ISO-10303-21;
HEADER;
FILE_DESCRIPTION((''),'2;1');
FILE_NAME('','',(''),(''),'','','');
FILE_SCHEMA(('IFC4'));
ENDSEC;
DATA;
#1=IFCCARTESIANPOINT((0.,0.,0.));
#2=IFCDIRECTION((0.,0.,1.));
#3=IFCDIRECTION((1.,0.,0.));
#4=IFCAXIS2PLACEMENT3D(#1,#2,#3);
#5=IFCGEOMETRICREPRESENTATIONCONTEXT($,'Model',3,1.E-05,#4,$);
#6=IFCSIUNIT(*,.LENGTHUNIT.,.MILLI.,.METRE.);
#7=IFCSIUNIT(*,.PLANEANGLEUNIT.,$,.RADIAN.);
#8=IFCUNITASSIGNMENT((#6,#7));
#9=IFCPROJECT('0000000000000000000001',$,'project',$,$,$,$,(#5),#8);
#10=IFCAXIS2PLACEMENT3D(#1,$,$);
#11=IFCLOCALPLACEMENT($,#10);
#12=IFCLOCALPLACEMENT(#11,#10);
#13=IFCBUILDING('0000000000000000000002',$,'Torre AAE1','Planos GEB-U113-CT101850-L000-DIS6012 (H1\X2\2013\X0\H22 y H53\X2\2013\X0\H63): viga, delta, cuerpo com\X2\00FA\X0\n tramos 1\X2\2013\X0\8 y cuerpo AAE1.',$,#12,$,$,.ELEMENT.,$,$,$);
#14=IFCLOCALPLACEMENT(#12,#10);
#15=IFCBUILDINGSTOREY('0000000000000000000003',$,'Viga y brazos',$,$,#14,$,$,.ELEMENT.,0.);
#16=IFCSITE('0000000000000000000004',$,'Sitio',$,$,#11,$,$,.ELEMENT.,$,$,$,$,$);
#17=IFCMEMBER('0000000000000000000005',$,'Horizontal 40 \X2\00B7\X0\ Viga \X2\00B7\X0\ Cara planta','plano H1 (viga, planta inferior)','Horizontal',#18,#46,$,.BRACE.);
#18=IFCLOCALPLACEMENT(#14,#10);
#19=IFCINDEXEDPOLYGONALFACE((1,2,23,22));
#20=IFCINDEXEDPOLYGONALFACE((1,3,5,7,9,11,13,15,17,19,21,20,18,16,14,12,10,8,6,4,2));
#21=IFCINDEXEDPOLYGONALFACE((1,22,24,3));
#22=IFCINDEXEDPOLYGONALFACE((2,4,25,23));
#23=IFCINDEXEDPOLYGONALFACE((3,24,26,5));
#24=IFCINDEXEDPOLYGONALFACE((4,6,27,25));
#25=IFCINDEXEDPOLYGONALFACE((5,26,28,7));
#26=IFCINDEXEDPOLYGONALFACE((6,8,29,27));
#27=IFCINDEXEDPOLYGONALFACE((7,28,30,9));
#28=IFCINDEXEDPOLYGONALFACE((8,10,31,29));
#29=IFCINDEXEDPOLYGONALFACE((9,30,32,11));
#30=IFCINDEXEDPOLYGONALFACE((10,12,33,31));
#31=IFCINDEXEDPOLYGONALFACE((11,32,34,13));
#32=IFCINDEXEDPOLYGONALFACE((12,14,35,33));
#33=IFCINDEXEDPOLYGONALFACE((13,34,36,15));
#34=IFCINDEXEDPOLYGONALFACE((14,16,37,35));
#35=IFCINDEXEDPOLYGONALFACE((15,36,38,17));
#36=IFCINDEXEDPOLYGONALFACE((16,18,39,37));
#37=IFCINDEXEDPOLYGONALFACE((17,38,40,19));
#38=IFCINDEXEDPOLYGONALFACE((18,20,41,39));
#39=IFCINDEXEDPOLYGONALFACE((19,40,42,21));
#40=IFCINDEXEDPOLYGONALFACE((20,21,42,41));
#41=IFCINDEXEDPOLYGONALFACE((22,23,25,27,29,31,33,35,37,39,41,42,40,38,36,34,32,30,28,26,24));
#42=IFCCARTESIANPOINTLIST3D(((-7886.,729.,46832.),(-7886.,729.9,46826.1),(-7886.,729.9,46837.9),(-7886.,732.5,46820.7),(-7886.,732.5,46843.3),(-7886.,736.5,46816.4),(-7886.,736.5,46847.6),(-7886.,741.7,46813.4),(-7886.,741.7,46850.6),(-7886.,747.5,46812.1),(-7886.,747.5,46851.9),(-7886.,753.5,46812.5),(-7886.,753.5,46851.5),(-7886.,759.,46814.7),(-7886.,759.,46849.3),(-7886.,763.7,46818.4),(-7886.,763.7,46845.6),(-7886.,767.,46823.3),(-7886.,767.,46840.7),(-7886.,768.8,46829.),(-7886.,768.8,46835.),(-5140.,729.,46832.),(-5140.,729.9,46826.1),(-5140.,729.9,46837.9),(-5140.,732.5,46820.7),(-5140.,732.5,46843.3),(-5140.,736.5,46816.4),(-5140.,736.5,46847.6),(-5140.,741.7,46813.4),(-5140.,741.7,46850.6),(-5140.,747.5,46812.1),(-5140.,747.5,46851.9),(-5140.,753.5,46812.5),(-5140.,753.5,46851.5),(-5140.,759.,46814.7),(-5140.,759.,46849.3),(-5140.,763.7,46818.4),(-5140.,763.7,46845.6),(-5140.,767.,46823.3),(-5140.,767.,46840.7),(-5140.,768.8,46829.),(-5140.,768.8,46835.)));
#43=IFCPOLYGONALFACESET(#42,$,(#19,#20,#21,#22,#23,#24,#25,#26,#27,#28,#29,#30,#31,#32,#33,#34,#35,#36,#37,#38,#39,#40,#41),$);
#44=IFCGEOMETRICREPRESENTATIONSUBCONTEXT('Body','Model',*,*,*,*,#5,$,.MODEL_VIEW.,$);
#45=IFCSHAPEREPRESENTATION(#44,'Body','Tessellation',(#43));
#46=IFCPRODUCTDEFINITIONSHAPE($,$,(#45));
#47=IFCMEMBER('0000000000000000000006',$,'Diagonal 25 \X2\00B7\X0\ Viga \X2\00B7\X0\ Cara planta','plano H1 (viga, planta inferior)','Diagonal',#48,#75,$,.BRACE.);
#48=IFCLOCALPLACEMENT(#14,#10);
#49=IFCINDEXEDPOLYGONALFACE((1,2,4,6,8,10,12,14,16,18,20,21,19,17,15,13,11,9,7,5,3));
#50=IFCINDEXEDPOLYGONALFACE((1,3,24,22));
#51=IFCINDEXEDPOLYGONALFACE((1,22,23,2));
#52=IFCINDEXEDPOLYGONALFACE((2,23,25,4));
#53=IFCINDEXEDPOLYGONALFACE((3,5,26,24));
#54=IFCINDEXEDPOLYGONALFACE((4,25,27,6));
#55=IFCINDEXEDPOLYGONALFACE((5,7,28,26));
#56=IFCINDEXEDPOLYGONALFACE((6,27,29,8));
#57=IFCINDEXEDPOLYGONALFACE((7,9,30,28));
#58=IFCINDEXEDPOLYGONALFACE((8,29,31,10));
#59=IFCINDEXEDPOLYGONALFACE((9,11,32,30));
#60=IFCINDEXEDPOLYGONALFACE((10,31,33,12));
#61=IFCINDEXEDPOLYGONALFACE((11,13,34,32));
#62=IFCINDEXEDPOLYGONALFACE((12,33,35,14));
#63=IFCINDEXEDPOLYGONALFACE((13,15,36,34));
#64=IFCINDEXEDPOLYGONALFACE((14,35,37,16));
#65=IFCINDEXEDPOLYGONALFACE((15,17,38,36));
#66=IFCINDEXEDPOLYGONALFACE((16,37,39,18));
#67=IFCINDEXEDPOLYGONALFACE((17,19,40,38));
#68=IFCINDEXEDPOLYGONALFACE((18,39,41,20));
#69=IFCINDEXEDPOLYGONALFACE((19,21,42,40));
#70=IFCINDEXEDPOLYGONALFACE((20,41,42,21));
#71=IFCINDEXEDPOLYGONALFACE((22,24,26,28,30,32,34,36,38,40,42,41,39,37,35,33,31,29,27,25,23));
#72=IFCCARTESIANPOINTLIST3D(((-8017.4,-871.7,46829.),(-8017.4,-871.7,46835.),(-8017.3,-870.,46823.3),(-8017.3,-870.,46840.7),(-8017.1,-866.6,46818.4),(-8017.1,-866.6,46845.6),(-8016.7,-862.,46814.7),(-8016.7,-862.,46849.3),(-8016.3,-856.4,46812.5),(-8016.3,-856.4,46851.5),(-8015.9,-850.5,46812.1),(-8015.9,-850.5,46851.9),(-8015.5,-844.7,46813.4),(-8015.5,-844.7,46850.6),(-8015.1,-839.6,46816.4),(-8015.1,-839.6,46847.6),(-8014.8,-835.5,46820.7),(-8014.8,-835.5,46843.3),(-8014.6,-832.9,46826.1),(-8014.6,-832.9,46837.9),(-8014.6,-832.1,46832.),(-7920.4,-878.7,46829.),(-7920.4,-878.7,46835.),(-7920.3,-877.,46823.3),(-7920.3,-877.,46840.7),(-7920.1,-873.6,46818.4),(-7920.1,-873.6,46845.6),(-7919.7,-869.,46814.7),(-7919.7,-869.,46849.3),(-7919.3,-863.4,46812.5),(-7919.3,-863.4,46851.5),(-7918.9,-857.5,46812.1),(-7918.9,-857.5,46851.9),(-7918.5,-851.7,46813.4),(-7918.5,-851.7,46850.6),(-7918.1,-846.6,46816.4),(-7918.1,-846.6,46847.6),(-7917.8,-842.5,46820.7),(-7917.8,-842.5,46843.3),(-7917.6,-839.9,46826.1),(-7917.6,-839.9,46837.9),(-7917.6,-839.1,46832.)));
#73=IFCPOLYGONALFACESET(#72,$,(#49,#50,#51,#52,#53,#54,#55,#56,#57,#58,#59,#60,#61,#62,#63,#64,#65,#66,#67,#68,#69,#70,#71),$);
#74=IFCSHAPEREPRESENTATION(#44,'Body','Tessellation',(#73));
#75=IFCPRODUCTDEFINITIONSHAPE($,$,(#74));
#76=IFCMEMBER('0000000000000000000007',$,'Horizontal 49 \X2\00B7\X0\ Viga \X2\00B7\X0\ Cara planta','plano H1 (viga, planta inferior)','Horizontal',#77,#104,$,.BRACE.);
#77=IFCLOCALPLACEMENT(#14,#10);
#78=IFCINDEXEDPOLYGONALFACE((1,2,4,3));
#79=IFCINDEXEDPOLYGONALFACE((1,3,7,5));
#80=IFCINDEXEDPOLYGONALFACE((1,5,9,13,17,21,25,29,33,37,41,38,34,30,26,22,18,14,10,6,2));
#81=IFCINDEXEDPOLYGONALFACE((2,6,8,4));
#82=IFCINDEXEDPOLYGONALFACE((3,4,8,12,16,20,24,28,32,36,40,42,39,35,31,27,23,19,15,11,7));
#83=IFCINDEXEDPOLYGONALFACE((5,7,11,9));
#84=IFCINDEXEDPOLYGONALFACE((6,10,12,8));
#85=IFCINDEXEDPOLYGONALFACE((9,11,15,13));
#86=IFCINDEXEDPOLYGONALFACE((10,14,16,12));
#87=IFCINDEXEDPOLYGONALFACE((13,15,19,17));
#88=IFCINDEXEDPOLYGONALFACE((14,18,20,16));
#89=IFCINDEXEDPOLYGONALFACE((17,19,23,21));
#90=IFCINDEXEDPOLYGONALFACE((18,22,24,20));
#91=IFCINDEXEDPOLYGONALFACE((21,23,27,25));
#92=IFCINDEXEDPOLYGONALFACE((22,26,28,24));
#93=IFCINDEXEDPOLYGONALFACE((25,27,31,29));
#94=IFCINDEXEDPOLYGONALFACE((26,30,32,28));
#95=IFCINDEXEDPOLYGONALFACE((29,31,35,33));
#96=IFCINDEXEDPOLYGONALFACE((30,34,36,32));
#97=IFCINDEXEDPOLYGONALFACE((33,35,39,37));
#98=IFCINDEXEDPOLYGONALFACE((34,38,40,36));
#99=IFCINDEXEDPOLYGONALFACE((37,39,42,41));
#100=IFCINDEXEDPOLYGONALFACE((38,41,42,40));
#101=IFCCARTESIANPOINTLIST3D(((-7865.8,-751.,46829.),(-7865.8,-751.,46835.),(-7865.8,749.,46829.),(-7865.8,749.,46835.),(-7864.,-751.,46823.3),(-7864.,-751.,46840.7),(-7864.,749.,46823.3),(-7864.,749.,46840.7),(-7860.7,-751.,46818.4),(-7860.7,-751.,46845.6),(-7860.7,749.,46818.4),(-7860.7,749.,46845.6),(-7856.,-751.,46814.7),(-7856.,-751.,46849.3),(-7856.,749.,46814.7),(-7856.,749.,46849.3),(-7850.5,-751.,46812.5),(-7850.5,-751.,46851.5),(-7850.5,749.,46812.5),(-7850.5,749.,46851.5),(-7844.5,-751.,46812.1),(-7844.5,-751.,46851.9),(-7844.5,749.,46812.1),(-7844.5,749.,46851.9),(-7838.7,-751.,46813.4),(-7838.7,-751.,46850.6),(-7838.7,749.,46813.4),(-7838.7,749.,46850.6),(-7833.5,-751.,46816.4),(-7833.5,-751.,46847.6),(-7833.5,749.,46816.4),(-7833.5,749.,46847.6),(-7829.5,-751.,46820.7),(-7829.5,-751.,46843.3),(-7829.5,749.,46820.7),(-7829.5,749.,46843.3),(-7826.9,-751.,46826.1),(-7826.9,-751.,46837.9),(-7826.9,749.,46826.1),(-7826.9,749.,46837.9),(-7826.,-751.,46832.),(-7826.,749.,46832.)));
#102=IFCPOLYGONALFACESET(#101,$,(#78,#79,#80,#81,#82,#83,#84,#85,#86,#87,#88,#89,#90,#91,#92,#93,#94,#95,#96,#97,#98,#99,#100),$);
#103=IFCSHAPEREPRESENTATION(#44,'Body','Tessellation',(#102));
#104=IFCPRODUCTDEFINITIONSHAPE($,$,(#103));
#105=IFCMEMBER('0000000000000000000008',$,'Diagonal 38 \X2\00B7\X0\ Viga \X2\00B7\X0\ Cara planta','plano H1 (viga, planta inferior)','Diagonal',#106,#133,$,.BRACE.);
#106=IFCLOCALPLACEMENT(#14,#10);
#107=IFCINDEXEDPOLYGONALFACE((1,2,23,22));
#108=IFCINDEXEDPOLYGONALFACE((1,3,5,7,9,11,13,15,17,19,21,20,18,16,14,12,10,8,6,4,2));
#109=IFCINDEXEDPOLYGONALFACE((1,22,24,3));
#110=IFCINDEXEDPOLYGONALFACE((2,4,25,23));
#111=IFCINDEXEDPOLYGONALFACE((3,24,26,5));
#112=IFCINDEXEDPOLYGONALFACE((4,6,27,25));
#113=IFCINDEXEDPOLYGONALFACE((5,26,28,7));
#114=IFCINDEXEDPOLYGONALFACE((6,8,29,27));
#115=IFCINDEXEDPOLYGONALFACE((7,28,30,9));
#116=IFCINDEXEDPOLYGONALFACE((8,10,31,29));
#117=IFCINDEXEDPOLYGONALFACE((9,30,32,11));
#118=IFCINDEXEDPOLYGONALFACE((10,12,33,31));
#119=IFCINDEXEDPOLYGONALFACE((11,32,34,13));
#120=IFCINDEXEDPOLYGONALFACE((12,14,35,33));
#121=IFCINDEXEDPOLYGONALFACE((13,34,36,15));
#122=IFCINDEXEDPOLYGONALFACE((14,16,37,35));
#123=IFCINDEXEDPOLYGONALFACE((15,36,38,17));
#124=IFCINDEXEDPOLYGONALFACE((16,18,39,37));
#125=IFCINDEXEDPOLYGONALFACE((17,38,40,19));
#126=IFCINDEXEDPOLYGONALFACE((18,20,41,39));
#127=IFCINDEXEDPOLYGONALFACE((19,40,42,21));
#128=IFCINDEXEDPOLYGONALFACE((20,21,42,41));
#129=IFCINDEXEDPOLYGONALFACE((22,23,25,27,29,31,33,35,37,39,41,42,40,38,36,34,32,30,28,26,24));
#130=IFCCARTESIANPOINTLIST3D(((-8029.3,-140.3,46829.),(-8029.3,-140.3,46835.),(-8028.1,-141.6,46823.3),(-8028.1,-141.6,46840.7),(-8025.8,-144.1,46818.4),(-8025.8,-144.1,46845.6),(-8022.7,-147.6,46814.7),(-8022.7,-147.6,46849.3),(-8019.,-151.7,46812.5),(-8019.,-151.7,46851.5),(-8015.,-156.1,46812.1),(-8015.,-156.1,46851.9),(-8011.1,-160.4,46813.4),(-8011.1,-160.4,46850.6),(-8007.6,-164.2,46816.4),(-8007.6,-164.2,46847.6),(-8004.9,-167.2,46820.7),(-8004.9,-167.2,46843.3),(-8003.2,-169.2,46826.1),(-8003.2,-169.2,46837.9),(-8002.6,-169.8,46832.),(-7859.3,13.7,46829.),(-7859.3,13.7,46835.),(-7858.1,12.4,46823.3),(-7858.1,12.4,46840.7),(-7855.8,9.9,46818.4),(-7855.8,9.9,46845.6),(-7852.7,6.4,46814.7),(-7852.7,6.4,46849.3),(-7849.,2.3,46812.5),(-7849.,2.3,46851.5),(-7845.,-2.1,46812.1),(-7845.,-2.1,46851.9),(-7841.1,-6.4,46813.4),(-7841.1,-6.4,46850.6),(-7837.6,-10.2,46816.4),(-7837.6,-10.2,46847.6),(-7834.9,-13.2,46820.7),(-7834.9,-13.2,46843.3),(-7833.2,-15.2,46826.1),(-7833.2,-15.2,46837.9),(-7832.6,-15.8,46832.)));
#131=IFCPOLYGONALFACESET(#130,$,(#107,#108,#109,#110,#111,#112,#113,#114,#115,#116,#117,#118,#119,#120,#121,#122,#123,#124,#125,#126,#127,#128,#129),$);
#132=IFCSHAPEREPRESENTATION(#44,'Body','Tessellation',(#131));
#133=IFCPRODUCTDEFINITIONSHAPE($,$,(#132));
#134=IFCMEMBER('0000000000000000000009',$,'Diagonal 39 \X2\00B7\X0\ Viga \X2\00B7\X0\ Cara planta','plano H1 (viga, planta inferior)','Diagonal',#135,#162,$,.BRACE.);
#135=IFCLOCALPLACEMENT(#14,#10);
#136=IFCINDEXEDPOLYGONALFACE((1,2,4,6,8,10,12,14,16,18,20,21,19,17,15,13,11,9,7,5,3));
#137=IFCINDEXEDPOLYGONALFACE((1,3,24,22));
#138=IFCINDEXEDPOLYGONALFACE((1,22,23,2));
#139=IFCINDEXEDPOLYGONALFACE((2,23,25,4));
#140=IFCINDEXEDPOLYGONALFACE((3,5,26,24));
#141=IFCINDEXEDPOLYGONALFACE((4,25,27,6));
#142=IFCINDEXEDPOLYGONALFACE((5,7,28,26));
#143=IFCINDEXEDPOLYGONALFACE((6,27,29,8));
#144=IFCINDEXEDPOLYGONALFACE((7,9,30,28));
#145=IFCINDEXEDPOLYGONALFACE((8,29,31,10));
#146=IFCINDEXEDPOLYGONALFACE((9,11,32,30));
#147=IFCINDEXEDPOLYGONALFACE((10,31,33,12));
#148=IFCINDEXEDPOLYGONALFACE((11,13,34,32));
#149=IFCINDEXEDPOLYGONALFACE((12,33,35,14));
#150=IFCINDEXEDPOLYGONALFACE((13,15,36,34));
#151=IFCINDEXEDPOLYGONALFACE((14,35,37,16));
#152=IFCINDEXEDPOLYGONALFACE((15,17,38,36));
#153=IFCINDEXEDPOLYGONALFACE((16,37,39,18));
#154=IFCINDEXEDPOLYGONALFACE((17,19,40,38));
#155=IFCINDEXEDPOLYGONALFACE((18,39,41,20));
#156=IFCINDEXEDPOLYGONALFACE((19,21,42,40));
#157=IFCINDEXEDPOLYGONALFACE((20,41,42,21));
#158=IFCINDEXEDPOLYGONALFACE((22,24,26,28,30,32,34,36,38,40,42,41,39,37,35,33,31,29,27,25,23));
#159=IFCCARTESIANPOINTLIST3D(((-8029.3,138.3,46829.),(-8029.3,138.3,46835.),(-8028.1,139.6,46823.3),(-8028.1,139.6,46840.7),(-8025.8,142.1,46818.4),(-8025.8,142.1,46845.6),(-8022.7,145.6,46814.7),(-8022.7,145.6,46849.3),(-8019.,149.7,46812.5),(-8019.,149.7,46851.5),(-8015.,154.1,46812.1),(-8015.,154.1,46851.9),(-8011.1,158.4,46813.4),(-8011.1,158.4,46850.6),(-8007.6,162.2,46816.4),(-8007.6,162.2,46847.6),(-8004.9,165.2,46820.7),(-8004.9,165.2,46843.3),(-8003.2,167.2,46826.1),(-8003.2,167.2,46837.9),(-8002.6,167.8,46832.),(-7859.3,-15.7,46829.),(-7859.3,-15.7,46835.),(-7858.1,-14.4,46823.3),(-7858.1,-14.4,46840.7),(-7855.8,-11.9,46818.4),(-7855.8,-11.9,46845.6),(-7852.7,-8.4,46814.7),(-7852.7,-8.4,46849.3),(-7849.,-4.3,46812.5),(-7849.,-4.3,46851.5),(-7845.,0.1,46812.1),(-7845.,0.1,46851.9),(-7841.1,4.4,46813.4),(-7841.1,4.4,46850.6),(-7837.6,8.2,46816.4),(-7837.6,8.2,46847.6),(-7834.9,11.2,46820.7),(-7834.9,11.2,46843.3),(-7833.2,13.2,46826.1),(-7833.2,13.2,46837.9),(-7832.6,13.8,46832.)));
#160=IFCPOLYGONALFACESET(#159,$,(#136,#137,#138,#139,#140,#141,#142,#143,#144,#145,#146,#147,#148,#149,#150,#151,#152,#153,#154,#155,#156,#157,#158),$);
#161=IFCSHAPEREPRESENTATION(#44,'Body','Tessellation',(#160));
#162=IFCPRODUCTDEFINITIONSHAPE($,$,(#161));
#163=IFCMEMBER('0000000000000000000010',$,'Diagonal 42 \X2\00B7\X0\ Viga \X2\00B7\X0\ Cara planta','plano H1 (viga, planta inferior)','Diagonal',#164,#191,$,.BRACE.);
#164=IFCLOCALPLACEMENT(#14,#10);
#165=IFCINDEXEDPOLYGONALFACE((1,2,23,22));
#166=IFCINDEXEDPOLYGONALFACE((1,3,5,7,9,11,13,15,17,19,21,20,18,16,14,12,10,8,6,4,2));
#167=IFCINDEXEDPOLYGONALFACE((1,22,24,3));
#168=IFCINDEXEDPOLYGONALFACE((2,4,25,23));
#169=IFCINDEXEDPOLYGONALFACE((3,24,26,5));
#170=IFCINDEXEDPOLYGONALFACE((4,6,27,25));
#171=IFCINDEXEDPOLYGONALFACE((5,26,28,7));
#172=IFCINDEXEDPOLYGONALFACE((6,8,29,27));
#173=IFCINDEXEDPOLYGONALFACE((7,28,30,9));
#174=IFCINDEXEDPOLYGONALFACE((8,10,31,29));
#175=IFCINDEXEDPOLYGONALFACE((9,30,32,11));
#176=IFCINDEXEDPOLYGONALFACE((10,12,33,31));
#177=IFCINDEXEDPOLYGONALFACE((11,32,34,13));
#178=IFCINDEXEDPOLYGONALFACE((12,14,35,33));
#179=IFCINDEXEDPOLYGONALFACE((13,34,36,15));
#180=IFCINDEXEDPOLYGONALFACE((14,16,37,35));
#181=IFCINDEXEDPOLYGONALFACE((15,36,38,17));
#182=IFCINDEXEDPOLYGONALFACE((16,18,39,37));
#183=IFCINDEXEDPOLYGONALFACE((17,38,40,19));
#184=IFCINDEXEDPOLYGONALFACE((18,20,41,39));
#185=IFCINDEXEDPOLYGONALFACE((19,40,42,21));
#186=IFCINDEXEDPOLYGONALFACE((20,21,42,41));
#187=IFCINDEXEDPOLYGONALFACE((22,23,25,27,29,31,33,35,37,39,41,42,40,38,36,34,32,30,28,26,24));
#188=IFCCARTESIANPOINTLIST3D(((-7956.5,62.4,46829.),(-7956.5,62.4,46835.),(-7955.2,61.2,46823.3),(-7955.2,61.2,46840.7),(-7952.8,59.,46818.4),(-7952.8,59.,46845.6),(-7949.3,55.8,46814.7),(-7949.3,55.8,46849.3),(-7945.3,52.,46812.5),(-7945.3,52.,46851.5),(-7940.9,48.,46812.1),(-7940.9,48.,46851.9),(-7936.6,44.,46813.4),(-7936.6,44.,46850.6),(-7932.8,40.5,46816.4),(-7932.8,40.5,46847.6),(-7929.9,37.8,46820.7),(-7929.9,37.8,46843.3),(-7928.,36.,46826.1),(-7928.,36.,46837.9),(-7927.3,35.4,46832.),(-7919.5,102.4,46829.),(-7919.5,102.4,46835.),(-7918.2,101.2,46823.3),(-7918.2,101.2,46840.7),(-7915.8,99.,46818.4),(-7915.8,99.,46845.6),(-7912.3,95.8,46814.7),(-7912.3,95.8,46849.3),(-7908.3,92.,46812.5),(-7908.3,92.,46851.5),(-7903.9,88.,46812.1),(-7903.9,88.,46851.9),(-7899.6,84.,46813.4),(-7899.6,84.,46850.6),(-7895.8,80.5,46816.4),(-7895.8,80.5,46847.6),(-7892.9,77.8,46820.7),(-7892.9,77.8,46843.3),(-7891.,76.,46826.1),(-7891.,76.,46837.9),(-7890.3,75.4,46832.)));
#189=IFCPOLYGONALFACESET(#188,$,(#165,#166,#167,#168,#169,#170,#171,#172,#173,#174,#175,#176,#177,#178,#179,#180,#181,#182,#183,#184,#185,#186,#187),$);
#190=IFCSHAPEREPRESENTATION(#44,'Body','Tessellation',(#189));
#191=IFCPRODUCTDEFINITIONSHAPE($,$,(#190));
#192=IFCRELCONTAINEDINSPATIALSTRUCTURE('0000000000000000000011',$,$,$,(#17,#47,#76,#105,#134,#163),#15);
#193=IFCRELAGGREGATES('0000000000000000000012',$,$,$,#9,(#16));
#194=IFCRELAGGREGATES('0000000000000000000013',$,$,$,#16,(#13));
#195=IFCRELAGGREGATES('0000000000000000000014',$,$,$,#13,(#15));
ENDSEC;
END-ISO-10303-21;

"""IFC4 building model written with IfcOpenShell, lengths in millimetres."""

from ifc_helpers import new_model, si_unit, frame, origin, origin_with_axes, place, context, subcontext, project, spatial, circle, extrude, element, save


model = new_model("IFC4")

# Units and contexts
model_context = context("Model", 3, precision=1e-05, world=origin_with_axes())
body_context = subcontext(model_context, "Body", "Model", "MODEL_VIEW")
ifc_project = project(units=[si_unit("LENGTHUNIT", "METRE", prefix="MILLI"), si_unit("PLANEANGLEUNIT", "RADIAN")], contexts=[model_context])

# Site, building, storey
site_placement = place(None, origin())
site = spatial("IfcSite", under=ifc_project, at=site_placement, Name="Sitio", CompositionType="ELEMENT")
building_placement = place(site_placement, origin())
building = spatial("IfcBuilding", under=site, at=building_placement, Name="Torre AAE1", Description="Planos GEB-U113-CT101850-L000-DIS6012 (H1–H22 y H53–H63): viga, delta, cuerpo común tramos 1–8 y cuerpo AAE1.", CompositionType="ELEMENT")
storey_placement = place(building_placement, origin())
storey = spatial("IfcBuildingStorey", under=building, at=storey_placement, Name="Viga y brazos", CompositionType="ELEMENT", Elevation=0.0)

# Members
member_1_placement = place(storey_placement, frame((-7886.0, 749.0, 46832.0), z_axis=(1.0, 0.0, 0.0), x_axis=(0.0, -1.0, 0.0)))
element("IfcMember", 1, at=member_1_placement, inside=storey, Name="Horizontal 40 · Viga · Cara planta", Description="plano H1 (viga, planta inferior)", ObjectType="Horizontal", PredefinedType="BRACE", context=body_context, shape_type="SweptSolid", body=[
    extrude(circle(Radius=20.0), None, (0.0, 0.0, 1.0), 2746.0),
])
member_2_placement = place(storey_placement, frame((-7919.0, -859.0, 46832.0), z_axis=(-0.997406, 0.071978, 0.0), x_axis=(0.071978, 0.997406, 0.0)))
element("IfcMember", 2, at=member_2_placement, inside=storey, Name="Diagonal 25 · Viga · Cara planta", Description="plano H1 (viga, planta inferior)", ObjectType="Diagonal", PredefinedType="BRACE", context=body_context, shape_type="SweptSolid", body=[
    extrude(circle(Radius=20.0), None, (0.0, 0.0, 1.0), 97.3),
])
member_3_placement = place(storey_placement, frame((-7846.0, 749.0, 46832.0), z_axis=(0.0, -1.0, 0.0), x_axis=(1.0, 0.0, 0.0)))
element("IfcMember", 3, at=member_3_placement, inside=storey, Name="Horizontal 49 · Viga · Cara planta", Description="plano H1 (viga, planta inferior)", ObjectType="Horizontal", PredefinedType="BRACE", context=body_context, shape_type="SweptSolid", body=[
    extrude(circle(Radius=20.0), None, (0.0, 0.0, 1.0), 1500.0),
])
for number, where, z_axis, x_axis, name in (
    (4, (-8016.0, -155.0, 46832.0), (0.741123, 0.67137, 0.0), (0.67137, -0.741123, 0.0), "Diagonal 38 · Viga · Cara planta"),
    (5, (-7846.0, -1.0, 46832.0), (-0.741123, 0.67137, 0.0), (0.67137, 0.741123, 0.0), "Diagonal 39 · Viga · Cara planta"),
):
    element("IfcMember", number, at=place(storey_placement, frame(where, z_axis=z_axis, x_axis=x_axis)), inside=storey, Name=name, Description="plano H1 (viga, planta inferior)", ObjectType="Diagonal", PredefinedType="BRACE", context=body_context, shape_type="SweptSolid", body=[
        extrude(circle(Radius=20.0), None, (0.0, 0.0, 1.0), 229.4),
    ])
for number, where, z_axis, x_axis, name in (
    (6, (-7905.0, 89.0, 46832.0), (-0.679042, -0.734099, 0.0), (0.734099, -0.679042, 0.0), "Diagonal 42 · Viga · Cara planta"),
):
    element("IfcMember", number, at=place(storey_placement, frame(where, z_axis=z_axis, x_axis=x_axis)), inside=storey, Name=name, Description="plano H1 (viga, planta inferior)", ObjectType="Diagonal", PredefinedType="BRACE", context=body_context, shape_type="SweptSolid", body=[
        extrude(circle(Radius=20.0), None, (0.0, 0.0, 1.0), 54.5),
    ])

save(model, "model.ifc")
